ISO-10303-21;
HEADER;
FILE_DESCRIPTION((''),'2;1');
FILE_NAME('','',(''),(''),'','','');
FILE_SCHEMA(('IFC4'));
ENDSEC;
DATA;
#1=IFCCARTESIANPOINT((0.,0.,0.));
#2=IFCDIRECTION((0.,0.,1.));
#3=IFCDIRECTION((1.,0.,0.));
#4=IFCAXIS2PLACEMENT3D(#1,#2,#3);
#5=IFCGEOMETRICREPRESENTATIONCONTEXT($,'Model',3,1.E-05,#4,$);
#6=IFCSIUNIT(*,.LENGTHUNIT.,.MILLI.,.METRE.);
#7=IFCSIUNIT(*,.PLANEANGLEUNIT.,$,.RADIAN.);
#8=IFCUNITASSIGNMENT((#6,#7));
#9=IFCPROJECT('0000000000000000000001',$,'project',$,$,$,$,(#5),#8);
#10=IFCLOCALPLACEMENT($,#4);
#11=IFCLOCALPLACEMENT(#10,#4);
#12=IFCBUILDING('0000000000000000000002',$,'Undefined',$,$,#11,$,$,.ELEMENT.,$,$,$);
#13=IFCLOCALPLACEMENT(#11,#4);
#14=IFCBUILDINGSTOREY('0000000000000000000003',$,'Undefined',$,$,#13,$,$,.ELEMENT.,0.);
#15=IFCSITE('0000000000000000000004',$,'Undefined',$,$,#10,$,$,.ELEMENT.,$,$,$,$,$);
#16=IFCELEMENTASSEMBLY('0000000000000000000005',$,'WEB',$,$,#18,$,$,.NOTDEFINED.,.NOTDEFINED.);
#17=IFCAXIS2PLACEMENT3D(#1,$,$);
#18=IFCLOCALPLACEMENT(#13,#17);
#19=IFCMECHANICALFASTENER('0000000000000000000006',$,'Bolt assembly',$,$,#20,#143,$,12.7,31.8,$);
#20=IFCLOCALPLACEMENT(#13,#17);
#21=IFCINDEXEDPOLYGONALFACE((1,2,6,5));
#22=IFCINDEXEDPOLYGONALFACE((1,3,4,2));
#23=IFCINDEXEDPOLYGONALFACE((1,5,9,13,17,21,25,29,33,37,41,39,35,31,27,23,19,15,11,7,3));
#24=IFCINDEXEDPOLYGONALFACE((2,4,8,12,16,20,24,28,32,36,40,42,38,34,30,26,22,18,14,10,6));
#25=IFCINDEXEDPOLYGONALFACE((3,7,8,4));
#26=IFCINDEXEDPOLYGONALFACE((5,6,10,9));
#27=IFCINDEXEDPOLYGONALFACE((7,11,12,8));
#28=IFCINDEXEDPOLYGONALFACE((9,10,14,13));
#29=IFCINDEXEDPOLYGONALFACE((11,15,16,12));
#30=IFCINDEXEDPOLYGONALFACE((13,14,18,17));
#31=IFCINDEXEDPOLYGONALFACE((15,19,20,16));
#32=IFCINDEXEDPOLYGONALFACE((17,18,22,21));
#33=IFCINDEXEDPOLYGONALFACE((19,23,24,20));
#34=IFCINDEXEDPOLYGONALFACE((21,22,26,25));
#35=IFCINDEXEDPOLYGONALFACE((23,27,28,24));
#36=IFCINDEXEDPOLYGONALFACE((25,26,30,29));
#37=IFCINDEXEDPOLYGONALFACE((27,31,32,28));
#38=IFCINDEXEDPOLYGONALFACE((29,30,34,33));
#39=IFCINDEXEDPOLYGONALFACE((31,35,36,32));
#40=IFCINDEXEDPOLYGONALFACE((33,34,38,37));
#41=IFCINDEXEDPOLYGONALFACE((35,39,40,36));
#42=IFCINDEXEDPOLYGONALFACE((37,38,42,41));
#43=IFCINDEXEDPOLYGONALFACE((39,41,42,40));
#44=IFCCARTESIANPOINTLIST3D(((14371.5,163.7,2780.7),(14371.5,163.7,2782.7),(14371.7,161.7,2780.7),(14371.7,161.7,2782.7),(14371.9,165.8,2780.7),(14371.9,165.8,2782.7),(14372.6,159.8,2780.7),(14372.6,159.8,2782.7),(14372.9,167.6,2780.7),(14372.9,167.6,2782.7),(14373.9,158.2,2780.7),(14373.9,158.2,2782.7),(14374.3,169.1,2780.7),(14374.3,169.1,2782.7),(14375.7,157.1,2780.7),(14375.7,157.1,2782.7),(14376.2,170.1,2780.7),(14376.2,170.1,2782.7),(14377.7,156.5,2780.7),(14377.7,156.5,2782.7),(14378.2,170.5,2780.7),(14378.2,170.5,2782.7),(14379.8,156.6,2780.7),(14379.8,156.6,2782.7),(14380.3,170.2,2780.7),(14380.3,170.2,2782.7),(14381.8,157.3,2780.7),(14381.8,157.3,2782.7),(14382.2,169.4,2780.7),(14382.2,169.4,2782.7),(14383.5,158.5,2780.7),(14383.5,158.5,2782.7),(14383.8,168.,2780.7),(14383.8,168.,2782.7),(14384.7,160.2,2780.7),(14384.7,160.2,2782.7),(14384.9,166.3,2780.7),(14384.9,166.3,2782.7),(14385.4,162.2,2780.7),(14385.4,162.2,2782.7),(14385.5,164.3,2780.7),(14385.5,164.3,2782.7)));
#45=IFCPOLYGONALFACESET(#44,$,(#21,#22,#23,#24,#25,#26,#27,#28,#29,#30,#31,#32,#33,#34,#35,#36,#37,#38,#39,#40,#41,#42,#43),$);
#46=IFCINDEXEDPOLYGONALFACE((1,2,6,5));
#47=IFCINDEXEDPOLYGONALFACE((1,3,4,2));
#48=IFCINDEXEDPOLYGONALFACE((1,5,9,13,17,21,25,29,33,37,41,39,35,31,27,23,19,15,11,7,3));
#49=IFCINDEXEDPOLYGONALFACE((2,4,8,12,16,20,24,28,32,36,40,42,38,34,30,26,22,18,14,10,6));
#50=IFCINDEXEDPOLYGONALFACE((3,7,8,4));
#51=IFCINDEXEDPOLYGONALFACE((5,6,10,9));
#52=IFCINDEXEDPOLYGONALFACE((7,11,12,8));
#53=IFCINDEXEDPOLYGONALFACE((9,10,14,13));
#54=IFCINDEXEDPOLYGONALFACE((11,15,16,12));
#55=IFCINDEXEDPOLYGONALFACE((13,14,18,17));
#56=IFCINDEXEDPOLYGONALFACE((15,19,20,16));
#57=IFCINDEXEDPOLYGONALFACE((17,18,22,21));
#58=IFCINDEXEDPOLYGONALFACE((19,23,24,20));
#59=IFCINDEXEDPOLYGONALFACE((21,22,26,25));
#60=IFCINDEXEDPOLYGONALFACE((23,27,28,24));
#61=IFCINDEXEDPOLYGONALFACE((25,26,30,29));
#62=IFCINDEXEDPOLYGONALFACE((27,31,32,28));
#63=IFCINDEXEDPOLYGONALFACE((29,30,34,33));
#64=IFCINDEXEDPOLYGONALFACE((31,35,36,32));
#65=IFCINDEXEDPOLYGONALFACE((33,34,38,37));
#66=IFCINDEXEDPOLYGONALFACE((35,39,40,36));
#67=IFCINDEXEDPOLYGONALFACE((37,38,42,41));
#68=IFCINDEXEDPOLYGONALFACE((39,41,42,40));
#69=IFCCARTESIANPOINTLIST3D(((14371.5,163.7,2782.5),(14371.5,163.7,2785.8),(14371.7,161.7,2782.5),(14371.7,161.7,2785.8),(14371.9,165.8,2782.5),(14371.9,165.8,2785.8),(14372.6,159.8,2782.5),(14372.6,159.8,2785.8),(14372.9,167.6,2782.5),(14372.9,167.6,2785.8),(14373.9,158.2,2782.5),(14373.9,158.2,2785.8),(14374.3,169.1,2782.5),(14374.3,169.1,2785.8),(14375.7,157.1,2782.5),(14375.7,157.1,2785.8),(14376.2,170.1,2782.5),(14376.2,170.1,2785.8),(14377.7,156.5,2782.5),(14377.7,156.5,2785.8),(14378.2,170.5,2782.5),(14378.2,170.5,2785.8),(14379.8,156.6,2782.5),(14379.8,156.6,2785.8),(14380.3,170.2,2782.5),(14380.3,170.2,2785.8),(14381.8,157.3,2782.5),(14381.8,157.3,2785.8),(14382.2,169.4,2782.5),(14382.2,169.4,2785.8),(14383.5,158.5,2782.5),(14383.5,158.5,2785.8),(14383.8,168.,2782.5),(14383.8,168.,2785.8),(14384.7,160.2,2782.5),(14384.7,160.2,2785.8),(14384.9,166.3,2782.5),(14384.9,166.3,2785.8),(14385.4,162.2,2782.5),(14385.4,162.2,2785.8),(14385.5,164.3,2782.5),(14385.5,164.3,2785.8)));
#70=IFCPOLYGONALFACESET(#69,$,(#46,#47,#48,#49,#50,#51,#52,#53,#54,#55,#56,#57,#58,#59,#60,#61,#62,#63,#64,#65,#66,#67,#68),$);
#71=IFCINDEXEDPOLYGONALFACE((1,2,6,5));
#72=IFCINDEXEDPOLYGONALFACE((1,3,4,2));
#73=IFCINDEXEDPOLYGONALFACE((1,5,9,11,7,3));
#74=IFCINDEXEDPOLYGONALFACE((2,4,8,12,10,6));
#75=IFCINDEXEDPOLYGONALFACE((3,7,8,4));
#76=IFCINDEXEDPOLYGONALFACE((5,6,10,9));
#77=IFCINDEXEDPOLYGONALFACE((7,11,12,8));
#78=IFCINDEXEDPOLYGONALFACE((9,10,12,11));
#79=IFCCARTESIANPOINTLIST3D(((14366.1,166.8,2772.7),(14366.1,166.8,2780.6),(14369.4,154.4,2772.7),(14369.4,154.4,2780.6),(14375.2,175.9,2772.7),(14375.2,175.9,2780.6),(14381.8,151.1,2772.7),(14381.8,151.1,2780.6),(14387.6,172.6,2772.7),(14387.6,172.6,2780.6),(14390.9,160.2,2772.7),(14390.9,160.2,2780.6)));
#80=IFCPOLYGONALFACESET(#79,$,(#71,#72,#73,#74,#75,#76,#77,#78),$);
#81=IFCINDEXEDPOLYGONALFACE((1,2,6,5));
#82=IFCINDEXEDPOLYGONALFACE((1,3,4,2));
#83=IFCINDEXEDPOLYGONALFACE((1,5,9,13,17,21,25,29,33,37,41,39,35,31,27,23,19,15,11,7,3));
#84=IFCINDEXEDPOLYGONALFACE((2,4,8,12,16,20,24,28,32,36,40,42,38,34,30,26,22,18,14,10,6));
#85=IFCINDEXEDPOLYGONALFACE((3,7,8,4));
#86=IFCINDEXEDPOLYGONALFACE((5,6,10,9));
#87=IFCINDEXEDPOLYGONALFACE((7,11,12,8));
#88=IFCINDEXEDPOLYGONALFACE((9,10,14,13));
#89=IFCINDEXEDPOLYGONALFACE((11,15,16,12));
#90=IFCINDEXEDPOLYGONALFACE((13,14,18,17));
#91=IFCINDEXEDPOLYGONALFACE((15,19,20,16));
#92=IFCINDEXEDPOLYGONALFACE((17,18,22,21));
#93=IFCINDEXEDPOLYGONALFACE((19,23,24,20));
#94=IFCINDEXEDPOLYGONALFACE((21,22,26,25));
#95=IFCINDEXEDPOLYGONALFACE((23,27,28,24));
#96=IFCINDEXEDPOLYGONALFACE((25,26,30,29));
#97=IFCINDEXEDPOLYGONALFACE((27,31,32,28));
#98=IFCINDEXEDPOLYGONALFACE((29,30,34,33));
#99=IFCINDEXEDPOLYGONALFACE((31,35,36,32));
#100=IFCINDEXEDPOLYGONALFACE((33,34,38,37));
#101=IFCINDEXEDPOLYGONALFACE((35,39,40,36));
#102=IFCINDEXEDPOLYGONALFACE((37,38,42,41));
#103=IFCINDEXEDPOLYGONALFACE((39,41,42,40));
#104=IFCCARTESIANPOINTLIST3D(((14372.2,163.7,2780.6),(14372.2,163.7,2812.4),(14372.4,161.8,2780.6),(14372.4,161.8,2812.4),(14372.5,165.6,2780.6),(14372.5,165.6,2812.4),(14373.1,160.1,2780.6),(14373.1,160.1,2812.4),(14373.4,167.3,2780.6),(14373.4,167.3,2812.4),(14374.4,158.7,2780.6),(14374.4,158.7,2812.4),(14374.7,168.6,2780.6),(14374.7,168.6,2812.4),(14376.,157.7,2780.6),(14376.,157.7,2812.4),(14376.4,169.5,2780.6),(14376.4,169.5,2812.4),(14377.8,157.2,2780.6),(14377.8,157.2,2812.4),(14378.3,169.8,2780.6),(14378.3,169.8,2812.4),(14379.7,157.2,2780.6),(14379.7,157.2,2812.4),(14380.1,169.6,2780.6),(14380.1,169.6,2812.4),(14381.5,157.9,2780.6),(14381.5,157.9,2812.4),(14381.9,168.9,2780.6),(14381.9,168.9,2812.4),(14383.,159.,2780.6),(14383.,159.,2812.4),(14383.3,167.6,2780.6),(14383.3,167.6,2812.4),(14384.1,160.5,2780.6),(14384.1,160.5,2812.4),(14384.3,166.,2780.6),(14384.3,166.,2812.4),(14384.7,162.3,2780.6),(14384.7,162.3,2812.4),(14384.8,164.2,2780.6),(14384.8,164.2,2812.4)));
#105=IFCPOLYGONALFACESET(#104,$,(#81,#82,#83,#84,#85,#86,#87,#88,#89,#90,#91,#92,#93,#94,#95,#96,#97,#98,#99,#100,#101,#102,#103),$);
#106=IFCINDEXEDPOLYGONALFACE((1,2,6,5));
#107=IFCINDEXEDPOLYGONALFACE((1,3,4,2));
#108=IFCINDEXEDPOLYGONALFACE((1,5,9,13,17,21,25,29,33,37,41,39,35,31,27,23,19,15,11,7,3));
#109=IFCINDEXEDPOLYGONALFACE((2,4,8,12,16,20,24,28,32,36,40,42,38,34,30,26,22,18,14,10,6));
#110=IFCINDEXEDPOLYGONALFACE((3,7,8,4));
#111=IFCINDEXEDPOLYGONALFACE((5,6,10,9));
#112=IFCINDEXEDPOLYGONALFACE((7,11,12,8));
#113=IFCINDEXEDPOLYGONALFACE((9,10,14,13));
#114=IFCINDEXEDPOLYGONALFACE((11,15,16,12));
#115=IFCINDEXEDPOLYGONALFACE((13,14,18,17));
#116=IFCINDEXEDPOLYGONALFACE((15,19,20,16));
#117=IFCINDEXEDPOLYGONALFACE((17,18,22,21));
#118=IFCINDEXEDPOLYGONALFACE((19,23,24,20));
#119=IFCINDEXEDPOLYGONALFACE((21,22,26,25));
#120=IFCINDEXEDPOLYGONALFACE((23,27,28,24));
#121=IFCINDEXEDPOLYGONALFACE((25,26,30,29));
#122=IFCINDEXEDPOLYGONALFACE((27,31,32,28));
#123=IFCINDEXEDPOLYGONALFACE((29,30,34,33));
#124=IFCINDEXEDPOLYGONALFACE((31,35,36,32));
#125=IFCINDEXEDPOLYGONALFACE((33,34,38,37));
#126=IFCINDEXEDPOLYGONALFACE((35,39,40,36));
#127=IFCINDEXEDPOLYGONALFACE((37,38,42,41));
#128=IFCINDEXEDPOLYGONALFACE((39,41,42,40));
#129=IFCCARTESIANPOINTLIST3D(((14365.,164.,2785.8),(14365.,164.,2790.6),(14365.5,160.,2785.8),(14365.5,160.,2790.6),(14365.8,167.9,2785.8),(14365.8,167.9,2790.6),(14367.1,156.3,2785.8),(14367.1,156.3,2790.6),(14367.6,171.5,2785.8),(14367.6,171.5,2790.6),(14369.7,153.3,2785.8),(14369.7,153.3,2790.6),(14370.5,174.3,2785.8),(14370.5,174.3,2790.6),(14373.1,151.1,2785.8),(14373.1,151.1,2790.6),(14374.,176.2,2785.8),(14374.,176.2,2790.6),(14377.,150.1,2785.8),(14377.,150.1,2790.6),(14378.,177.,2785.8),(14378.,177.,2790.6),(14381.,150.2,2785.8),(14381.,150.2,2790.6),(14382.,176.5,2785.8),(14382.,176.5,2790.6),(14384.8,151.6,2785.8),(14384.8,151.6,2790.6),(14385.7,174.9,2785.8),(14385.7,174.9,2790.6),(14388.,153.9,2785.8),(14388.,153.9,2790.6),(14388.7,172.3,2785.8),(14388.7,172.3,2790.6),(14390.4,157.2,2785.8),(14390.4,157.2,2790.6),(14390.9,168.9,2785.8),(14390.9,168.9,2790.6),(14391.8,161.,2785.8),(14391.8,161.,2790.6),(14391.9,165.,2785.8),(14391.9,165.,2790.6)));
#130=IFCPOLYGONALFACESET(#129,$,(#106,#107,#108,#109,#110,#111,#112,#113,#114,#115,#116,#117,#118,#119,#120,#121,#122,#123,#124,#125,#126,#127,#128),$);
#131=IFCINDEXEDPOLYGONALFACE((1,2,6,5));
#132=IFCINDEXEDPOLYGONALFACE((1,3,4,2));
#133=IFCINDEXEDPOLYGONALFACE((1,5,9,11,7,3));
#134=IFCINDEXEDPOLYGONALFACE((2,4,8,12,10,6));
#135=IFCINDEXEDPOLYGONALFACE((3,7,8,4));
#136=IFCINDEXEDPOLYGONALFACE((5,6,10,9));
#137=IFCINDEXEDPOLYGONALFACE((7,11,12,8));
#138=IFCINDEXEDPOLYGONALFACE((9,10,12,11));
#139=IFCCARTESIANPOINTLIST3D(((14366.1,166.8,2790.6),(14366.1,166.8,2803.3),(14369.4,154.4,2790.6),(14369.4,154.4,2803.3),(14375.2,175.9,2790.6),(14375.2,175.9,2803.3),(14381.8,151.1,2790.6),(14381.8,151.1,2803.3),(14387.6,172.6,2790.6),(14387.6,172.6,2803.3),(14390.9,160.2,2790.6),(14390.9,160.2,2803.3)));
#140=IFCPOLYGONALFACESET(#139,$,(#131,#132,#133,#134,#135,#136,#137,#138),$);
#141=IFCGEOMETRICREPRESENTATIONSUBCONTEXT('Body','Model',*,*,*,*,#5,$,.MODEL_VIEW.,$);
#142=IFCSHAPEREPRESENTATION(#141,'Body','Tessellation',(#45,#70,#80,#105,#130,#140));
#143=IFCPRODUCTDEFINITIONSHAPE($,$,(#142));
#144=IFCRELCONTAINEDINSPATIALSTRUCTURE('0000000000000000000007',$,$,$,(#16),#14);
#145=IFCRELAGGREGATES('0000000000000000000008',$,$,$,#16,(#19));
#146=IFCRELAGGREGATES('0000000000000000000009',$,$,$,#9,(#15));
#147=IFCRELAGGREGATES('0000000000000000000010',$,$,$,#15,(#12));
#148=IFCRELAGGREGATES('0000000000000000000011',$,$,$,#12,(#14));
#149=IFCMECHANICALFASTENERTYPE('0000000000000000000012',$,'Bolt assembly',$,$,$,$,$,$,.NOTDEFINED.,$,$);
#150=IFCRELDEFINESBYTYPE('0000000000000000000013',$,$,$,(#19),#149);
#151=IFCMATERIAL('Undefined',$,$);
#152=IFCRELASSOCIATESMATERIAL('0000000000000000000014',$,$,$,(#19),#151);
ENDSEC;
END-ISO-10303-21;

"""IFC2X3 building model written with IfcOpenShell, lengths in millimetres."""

from ifc_helpers import new_model, si_unit, frame, origin_with_axes, origin_2d_with_axis, place, context, subcontext, project, spatial, polyline, circle, outline, extrude, source, transform, mapped, material, type_object, element, aggregate, save


model = new_model("IFC2X3")

# Units and contexts
model_context = context("Model", 3, precision=1e-05, world=origin_with_axes())
body_context = subcontext(model_context, "Body", "Model", "MODEL_VIEW")
ifc_project = project(units=[si_unit("LENGTHUNIT", "METRE", prefix="MILLI"), si_unit("PLANEANGLEUNIT", "RADIAN")], contexts=[model_context])

# Site, building, storey
site_placement = place(None, origin_with_axes())
site = spatial("IfcSite", under=ifc_project, at=site_placement, Name="Undefined", CompositionType="ELEMENT")
building_placement = place(site_placement, origin_with_axes())
building = spatial("IfcBuilding", under=site, at=building_placement, Name="Undefined", CompositionType="ELEMENT")
storey_placement = place(building_placement, origin_with_axes())
storey = spatial("IfcBuildingStorey", under=building, at=storey_placement, Name="Undefined", CompositionType="ELEMENT", Elevation=0.0)

# Element assembly, mechanical fastener
assembly_1_placement = place(storey_placement, origin_with_axes())
assembly_1 = element("IfcElementAssembly", 1, at=assembly_1_placement, inside=storey, Name="WEB", AssemblyPlace="NOTDEFINED", PredefinedType="NOTDEFINED")
ifc_material_1 = material(Name="Undefined")
mechanical_fastener_type = type_object("IfcMechanicalFastenerType", Name="Bolt assembly")
shared_shape_1 = source(origin_with_axes(), body_context, "Body", "SweptSolid", [
    extrude(circle(Radius=7.0, at=origin_2d_with_axis()), frame((0.0, -1.9, 0.0), z_axis=(0.0, 1.0, 0.0), x_axis=(1.0, 0.0, 0.0)), (0.0, 0.0, 1.0), 2.0),
    extrude(circle(Radius=7.0, at=origin_2d_with_axis()), frame((0.0, -0.1, 0.0), z_axis=(0.0, 1.0, 0.0), x_axis=(1.0, 0.0, 0.0)), (0.0, 0.0, 1.0), 3.3),
    extrude(outline(polyline([(11.1, -6.4), (11.1, 6.4), (0.0, 12.8), (-11.1, 6.4), (-11.1, -6.4), (0.0, -12.8), (11.1, -6.4)])), frame((0.0, -9.9, 0.0), z_axis=(0.0, 1.0, 0.0), x_axis=(1.0, 0.0, 0.0)), (0.0, 0.0, 1.0), 7.9),
    extrude(circle(Radius=6.3, at=origin_2d_with_axis()), frame((0.0, -2.0, 0.0), z_axis=(0.0, 1.0, 0.0), x_axis=(1.0, 0.0, 0.0)), (0.0, 0.0, 1.0), 31.8),
    extrude(circle(Radius=13.5, at=origin_2d_with_axis()), frame((0.0, 3.2, 0.0), z_axis=(0.0, 1.0, 0.0), x_axis=(1.0, 0.0, 0.0)), (0.0, 0.0, 1.0), 4.8),
    extrude(outline(polyline([(11.1, -6.4), (11.1, 6.4), (0.0, 12.8), (-11.1, 6.4), (-11.1, -6.4), (0.0, -12.8), (11.1, -6.4)])), frame((0.0, 8.0, 0.0), z_axis=(0.0, 1.0, 0.0), x_axis=(1.0, 0.0, 0.0)), (0.0, 0.0, 1.0), 12.7),
])
mechanical_fastener_1_placement = place(assembly_1_placement, frame((14378.5, 163.5, 2782.6), z_axis=(-0.707106, -0.707107, 0.000005), x_axis=(0.707107, -0.707107, 0.000005)))
mechanical_fastener_1 = element("IfcMechanicalFastener", 2, at=mechanical_fastener_1_placement, type_object=mechanical_fastener_type, material=ifc_material_1, Name="Bolt assembly", NominalDiameter=12.7, NominalLength=31.8, context=body_context, shape_type="MappedRepresentation", body=[
    mapped(shared_shape_1, transform((0.0, 0.0, 0.0))),
])

aggregate(assembly_1, [mechanical_fastener_1])

save(model, "model.ifc")
